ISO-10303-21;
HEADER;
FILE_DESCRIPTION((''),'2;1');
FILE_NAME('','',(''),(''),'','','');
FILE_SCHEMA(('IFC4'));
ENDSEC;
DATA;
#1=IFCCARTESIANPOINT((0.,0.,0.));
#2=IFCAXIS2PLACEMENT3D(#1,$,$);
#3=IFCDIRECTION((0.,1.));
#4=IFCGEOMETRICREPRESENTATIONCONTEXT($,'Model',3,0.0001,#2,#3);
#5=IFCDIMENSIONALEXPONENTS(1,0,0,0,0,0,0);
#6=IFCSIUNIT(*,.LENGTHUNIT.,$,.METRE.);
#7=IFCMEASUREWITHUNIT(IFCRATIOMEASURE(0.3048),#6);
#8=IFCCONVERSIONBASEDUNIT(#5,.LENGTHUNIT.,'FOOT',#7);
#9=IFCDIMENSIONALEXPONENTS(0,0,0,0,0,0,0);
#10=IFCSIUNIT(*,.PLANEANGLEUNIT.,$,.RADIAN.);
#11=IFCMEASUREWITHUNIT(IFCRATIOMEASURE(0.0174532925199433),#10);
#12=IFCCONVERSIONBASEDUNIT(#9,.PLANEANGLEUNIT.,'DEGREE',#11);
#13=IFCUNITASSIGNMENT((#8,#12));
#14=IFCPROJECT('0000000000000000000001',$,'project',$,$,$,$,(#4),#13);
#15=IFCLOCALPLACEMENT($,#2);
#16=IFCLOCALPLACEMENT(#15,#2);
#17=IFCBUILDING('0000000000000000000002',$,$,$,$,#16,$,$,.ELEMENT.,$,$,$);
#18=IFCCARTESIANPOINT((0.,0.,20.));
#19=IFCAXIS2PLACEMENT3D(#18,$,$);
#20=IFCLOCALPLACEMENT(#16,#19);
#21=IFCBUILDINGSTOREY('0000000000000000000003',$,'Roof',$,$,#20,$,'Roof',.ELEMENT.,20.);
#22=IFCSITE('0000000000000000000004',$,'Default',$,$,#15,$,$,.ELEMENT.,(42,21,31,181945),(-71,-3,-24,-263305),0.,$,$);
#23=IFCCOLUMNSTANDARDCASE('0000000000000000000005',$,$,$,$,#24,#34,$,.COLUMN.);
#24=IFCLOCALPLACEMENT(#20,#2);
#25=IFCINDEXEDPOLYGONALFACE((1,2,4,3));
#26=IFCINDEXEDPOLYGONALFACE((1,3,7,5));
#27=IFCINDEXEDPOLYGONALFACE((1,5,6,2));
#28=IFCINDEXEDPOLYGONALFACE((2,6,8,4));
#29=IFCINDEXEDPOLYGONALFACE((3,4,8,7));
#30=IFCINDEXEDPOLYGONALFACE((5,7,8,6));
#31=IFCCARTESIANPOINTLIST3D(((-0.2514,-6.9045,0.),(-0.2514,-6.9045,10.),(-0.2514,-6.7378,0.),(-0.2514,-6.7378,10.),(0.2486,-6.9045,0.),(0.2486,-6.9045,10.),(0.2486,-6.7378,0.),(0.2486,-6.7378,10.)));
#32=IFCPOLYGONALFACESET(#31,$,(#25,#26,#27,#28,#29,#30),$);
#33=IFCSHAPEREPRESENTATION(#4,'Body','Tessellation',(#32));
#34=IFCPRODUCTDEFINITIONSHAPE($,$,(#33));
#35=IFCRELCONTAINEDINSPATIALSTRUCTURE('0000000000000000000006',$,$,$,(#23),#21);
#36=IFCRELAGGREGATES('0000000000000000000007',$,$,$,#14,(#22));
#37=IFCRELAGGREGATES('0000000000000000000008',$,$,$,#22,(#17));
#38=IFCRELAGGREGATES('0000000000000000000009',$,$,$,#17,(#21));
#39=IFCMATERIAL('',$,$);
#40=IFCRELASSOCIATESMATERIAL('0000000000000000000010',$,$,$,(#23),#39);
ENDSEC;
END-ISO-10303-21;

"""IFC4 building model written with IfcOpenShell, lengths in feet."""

from ifc_helpers import new_model, entity, si_unit, converted_unit, direction, frame, origin, place, context, project, spatial, rectangle, extrude, material, element, save


model = new_model("IFC4")

# Units and contexts
model_context = context("Model", 3, precision=0.0001, world=origin(), true_north=direction((0.0, 1.0)))
ifc_project = project(units=[converted_unit("LENGTHUNIT", "FOOT", entity("IfcRatioMeasure", 0.3048), si_unit("LENGTHUNIT", "METRE"), dimensions=[1, 0, 0, 0, 0, 0, 0]), converted_unit("PLANEANGLEUNIT", "DEGREE", entity("IfcRatioMeasure", 0.0174532925199433), si_unit("PLANEANGLEUNIT", "RADIAN"), dimensions=[0, 0, 0, 0, 0, 0, 0])], contexts=[model_context])

# Site, building, storey
site_placement = place(None, origin())
site = spatial("IfcSite", under=ifc_project, at=site_placement, Name="Default", CompositionType="ELEMENT", RefLatitude=(42, 21, 31, 181945), RefLongitude=(-71, -3, -24, -263305), RefElevation=0.0)
building_placement = place(site_placement, origin())
building = spatial("IfcBuilding", under=site, at=building_placement, CompositionType="ELEMENT")
storey_placement = place(building_placement, frame((0.0, 0.0, 20.0)))
storey = spatial("IfcBuildingStorey", under=building, at=storey_placement, Name="Roof", LongName="Roof", CompositionType="ELEMENT", Elevation=20.0)

# Column
ifc_material_1 = material(Name="")
wall_placement = place(storey_placement, frame((-0.0014, -6.9045, 0.0), z_axis=(0.0, 0.0, 1.0), x_axis=(0.0, 1.0, 0.0)))
for number, where, z_axis, x_axis in (
    (1, (0.0833, 0.0, 0.0), (0.0, 0.0, 1.0), (1.0, 0.0, 0.0)),
):
    element("IfcColumnStandardCase", number, at=place(wall_placement, frame(where, z_axis=z_axis, x_axis=x_axis)), inside=storey, material=ifc_material_1, PredefinedType="COLUMN", context=model_context, shape_type="SweptSolid", body=[
        extrude(rectangle(XDim=0.1667, YDim=0.5), origin(), (0.0, 0.0, 1.0), 10.0),
    ])

save(model, "model.ifc")
